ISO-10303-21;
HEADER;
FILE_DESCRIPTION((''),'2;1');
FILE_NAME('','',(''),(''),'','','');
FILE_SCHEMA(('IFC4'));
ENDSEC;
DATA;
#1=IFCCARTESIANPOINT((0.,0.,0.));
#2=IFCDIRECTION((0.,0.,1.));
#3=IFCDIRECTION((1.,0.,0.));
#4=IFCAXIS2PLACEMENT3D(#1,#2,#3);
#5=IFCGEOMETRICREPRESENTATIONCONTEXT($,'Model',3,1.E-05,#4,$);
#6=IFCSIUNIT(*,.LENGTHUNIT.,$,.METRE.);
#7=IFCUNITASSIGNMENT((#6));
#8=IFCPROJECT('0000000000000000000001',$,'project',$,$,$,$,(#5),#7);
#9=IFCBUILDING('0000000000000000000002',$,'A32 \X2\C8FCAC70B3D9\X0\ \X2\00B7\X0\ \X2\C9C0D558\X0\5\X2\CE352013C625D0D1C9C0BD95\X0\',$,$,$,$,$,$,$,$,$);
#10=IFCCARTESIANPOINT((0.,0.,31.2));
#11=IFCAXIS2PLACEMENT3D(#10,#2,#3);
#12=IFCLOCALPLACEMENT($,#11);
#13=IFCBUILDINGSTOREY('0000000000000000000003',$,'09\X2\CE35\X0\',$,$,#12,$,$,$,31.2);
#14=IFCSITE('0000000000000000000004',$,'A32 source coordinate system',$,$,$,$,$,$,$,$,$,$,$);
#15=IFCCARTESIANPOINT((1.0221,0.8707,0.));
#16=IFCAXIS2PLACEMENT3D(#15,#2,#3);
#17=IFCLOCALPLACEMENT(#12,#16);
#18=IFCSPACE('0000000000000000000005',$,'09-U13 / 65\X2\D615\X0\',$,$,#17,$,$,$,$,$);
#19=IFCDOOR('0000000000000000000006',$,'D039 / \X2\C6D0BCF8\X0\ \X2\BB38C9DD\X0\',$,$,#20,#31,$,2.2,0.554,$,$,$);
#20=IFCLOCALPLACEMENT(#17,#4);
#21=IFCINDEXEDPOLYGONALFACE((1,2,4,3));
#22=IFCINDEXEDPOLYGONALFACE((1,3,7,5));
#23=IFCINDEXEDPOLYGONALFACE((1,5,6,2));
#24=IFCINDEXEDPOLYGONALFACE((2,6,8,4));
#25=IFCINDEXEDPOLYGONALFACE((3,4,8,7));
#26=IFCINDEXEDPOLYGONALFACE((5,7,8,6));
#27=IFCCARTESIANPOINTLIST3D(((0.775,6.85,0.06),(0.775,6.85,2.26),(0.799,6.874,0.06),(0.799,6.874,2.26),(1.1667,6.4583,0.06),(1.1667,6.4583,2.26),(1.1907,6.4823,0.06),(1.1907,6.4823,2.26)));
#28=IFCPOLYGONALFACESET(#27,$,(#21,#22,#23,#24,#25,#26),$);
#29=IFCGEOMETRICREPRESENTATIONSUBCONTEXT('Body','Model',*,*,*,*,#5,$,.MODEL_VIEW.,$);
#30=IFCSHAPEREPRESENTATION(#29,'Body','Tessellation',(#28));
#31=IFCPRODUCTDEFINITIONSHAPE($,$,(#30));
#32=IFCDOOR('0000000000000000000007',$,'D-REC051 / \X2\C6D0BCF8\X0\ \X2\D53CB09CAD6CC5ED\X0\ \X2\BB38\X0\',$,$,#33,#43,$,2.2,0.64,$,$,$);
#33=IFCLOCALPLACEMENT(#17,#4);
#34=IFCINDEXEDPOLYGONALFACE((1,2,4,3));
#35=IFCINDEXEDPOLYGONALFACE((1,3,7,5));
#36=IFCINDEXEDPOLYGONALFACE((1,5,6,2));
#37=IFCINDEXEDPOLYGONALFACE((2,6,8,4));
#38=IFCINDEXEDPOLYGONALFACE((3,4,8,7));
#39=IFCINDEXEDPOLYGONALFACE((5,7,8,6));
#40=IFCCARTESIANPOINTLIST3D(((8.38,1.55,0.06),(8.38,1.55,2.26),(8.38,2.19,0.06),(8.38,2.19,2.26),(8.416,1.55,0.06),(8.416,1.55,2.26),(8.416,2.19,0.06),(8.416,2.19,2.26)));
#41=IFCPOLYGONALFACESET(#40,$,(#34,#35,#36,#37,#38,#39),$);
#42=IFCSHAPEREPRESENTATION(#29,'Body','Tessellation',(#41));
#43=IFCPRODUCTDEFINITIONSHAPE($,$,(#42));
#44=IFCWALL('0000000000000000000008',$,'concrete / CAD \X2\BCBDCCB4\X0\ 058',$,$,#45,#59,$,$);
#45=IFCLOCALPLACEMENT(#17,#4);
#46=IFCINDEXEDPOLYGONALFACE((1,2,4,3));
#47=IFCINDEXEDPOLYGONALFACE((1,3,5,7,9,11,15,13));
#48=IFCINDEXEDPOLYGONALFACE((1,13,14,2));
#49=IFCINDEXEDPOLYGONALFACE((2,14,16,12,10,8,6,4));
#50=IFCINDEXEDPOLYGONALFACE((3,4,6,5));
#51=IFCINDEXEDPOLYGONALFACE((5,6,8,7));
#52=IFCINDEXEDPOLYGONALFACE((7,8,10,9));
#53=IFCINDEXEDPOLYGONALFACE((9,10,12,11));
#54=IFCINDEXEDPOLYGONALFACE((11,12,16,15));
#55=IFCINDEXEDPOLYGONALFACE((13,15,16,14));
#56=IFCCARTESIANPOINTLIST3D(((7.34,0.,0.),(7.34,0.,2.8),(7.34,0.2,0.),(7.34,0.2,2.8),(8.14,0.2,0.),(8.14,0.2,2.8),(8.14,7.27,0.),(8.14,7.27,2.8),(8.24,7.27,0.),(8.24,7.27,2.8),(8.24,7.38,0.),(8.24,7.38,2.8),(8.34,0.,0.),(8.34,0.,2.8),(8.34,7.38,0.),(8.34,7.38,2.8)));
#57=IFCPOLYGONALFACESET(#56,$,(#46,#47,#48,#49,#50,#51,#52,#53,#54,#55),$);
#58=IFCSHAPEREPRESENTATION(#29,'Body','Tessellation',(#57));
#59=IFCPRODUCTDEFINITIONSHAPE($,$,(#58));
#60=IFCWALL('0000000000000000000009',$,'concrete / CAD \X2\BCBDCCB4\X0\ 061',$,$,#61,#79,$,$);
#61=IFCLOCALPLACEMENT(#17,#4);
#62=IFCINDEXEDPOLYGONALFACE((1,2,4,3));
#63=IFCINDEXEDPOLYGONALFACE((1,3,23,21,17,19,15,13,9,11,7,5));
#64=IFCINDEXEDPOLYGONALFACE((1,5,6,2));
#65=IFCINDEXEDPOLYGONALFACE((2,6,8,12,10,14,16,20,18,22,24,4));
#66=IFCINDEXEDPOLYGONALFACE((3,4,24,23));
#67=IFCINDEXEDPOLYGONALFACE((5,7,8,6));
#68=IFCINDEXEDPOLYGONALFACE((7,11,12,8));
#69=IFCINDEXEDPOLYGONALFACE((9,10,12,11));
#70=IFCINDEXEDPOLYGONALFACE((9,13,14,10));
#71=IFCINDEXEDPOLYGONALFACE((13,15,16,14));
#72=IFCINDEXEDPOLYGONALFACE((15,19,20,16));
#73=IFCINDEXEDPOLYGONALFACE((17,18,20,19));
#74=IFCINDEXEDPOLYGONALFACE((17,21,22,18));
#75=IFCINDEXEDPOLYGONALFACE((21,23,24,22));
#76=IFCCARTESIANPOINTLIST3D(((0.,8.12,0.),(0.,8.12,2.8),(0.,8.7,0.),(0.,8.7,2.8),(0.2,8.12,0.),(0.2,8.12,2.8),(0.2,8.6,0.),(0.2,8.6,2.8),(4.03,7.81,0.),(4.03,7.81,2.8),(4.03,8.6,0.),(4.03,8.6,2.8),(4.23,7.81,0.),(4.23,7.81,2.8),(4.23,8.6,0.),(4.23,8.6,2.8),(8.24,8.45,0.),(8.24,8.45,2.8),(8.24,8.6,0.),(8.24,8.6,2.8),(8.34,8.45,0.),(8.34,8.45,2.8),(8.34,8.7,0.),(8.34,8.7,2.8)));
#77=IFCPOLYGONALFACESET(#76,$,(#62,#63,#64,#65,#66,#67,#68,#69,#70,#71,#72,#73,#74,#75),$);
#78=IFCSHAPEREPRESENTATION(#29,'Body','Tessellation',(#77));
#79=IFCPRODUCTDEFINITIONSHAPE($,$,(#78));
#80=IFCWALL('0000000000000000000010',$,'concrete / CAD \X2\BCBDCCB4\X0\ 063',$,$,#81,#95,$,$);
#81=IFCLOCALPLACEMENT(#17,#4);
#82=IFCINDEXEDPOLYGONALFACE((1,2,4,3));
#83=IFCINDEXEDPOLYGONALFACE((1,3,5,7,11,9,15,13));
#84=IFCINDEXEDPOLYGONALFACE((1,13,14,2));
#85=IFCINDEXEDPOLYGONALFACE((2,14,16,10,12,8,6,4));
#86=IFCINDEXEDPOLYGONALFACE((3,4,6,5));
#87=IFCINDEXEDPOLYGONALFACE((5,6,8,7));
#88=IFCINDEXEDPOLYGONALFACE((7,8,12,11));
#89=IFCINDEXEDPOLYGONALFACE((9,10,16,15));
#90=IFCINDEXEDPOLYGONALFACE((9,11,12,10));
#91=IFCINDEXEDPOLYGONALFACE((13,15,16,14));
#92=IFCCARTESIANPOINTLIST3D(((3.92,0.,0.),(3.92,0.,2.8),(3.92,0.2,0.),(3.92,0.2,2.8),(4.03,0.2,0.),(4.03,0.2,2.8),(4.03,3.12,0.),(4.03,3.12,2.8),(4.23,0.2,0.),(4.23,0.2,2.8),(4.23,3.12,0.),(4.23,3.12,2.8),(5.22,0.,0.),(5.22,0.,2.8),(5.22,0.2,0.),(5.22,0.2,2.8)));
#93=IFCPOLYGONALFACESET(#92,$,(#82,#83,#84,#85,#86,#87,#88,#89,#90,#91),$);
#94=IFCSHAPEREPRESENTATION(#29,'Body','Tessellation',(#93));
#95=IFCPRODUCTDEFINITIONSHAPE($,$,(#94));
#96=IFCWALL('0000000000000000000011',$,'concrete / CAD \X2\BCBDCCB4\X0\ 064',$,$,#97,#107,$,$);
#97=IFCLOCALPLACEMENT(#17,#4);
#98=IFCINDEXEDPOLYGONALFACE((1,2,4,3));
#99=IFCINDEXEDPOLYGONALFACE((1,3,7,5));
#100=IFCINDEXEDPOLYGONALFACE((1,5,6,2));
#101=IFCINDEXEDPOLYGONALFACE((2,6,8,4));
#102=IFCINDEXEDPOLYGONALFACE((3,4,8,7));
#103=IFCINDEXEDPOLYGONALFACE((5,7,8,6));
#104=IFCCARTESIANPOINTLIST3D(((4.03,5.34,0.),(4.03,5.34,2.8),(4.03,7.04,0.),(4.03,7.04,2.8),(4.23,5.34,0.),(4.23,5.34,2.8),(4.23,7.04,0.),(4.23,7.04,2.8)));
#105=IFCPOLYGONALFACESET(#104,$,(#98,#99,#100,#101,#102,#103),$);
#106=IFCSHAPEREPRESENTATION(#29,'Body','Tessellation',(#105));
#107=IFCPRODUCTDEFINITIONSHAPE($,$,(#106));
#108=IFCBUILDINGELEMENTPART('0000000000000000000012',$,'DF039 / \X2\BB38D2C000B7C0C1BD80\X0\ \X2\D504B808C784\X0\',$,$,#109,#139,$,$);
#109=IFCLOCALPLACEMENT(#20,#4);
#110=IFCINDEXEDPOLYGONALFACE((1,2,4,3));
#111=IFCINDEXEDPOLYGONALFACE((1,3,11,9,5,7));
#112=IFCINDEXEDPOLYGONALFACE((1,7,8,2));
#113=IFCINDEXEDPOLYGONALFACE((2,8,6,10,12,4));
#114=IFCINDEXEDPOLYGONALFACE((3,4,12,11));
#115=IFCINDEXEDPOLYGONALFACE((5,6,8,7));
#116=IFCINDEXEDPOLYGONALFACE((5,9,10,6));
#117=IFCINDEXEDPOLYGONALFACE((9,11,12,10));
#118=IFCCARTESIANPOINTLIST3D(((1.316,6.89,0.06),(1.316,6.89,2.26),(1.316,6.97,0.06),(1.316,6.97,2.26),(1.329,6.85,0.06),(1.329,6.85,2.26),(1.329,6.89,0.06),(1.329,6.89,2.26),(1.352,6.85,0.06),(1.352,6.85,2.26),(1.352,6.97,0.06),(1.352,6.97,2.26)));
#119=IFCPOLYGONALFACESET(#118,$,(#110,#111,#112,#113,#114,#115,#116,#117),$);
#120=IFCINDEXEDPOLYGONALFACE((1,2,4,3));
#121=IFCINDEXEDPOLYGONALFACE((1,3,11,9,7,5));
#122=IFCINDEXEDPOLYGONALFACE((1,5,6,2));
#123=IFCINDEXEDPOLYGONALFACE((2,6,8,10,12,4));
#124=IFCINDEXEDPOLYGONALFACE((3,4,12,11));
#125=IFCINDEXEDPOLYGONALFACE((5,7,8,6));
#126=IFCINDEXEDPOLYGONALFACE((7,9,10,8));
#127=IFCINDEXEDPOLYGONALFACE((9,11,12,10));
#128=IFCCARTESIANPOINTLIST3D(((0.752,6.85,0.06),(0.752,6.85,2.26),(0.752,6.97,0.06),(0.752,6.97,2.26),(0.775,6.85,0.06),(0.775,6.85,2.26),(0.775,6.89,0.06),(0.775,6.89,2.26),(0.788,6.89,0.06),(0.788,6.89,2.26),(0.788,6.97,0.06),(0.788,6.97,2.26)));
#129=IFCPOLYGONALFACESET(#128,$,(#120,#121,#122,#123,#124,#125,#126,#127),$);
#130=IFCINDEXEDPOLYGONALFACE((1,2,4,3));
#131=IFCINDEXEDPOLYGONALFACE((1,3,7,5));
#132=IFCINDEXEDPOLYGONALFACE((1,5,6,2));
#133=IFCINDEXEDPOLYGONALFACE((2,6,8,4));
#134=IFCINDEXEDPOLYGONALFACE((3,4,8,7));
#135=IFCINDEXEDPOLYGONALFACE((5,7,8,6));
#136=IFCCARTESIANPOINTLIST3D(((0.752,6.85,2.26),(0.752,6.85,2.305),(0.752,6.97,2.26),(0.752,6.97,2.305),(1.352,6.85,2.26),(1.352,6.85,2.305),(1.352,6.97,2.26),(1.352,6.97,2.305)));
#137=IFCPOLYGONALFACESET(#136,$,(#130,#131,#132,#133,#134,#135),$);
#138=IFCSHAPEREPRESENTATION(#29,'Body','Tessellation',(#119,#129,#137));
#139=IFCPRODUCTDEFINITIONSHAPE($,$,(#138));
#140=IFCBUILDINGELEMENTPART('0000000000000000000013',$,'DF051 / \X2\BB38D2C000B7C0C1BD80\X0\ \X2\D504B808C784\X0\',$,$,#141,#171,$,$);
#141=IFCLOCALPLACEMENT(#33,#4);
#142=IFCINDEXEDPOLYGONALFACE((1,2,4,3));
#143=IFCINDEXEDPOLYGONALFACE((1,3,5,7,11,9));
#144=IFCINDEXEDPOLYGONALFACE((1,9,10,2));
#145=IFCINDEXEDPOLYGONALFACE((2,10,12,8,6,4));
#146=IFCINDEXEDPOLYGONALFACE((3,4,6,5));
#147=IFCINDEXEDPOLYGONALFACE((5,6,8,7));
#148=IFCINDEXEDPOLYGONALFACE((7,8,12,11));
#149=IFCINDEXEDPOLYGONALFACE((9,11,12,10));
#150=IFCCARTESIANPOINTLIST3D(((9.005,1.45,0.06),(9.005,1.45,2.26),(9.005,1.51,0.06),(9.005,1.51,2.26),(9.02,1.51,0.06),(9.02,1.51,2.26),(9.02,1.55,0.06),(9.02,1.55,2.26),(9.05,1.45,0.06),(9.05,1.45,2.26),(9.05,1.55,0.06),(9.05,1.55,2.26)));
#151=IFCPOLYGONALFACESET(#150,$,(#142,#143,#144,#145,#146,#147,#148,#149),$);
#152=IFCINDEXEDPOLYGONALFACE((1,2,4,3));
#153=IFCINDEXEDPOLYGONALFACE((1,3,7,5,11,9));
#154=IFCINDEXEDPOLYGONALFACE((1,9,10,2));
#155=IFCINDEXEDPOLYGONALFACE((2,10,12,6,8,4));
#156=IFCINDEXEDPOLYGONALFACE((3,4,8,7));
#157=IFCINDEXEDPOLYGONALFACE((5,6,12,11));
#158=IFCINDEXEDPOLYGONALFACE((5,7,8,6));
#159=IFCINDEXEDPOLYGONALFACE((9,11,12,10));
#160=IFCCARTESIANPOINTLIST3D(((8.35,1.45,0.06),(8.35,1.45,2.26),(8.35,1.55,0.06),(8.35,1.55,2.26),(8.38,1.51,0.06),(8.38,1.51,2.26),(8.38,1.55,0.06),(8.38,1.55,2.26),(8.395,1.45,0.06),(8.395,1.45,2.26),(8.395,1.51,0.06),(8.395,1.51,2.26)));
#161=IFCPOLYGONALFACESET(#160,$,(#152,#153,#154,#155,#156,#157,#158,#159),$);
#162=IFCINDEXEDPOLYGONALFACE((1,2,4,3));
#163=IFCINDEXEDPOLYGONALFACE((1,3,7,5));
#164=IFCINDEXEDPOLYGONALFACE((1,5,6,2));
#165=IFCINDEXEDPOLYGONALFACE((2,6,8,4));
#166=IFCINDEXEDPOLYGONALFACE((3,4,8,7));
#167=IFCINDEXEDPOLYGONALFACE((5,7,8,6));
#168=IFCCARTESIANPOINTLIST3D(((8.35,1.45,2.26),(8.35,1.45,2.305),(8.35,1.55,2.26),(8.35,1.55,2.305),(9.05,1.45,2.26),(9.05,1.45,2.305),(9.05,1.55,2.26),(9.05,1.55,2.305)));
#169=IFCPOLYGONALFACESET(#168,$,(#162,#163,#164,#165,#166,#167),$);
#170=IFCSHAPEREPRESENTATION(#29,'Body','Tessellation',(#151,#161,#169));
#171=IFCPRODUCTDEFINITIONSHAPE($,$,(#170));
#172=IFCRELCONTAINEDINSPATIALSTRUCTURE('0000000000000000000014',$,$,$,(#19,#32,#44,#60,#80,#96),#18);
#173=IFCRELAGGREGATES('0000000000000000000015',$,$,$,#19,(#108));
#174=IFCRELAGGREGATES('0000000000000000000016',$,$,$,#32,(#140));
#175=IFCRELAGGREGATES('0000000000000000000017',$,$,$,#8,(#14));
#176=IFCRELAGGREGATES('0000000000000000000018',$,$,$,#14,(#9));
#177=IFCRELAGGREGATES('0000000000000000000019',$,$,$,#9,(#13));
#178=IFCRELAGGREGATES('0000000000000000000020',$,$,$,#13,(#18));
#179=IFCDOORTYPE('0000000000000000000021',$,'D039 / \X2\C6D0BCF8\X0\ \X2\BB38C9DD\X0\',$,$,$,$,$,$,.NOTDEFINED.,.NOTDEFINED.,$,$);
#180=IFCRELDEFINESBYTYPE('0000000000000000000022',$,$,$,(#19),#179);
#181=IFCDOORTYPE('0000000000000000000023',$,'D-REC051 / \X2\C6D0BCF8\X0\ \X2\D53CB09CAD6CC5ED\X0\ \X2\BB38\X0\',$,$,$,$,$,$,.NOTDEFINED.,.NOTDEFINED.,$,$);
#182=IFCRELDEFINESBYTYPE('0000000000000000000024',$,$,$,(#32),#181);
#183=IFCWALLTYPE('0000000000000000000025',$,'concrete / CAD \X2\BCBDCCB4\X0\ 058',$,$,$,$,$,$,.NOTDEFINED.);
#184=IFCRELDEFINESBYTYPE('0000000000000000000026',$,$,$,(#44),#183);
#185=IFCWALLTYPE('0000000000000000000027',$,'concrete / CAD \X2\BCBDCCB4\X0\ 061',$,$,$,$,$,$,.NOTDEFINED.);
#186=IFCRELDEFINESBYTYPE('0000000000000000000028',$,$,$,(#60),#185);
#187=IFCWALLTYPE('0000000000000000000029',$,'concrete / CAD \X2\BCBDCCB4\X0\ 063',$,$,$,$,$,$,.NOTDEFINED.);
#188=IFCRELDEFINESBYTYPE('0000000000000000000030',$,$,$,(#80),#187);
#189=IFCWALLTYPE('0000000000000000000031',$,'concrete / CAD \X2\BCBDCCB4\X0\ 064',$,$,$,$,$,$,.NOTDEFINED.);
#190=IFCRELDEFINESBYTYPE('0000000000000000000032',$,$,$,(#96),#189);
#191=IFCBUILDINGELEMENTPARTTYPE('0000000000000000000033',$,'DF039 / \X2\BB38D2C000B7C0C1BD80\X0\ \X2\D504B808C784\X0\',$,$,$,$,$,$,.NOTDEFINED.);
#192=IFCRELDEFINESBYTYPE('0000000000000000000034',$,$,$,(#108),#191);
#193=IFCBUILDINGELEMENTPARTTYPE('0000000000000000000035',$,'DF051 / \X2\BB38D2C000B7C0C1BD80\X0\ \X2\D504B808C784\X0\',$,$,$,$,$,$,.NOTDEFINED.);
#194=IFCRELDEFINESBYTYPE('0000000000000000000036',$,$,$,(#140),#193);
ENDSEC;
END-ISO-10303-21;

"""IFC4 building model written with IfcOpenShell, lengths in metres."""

from ifc_helpers import new_model, si_unit, frame, origin, origin_with_axes, place, context, subcontext, project, spatial, polyline, outline, extrude, source, transform, mapped, type_object, type_shapes, element, aggregate, save


model = new_model("IFC4")

# Units and contexts
model_context = context("Model", 3, precision=1e-05, world=origin_with_axes())
body_context = subcontext(model_context, "Body", "Model", "MODEL_VIEW")
ifc_project = project(units=[si_unit("LENGTHUNIT", "METRE")], contexts=[model_context])

# Site, building, storey, space
storey_placement = place(None, frame((0.0, 0.0, 31.2), z_axis=(0.0, 0.0, 1.0), x_axis=(1.0, 0.0, 0.0)))
space_placement = place(storey_placement, frame((1.0221, 0.8707, 0.0), z_axis=(0.0, 0.0, 1.0), x_axis=(1.0, 0.0, 0.0)))
site = spatial("IfcSite", under=ifc_project, Name="A32 source coordinate system")
building = spatial("IfcBuilding", under=site, Name="A32 주거동 · 지하5층–옥탑지붕")
storey = spatial("IfcBuildingStorey", under=building, at=storey_placement, Name="09층", Elevation=31.2)
space = spatial("IfcSpace", under=storey, at=space_placement, Name="09-U13 / 65형")

# Doors
door_type_1 = type_object("IfcDoorType", Name="D039 / 원본 문짝", OperationType="NOTDEFINED", PredefinedType="NOTDEFINED")
shared_shape_1 = source(origin(), body_context, "Body", "SweptSolid", [
    extrude(outline(polyline([(1.1907, 6.4823), (1.1667, 6.4583), (0.775, 6.85), (0.799, 6.874), (1.1907, 6.4823)])), frame((0.0, 0.0, 0.06)), (0.0, 0.0, 1.0), 2.2),
])
type_shapes(door_type_1, [shared_shape_1])
door_1_placement = place(space_placement, origin_with_axes())
door_1 = element("IfcDoor", 1, at=door_1_placement, inside=space, type_object=door_type_1, Name="D039 / 원본 문짝", OverallHeight=2.2, OverallWidth=0.554, context=body_context, shape_type="MappedRepresentation", body=[
    mapped(shared_shape_1, transform((0.0, 0.0, 0.0), scale=1.0)),
])
door_type_2 = type_object("IfcDoorType", Name="D-REC051 / 원본 피난구역 문", OperationType="NOTDEFINED", PredefinedType="NOTDEFINED")
shared_shape_2 = source(origin(), body_context, "Body", "SweptSolid", [
    extrude(outline(polyline([(8.416, 2.19), (8.416, 1.55), (8.38, 1.55), (8.38, 2.19), (8.416, 2.19)])), frame((0.0, 0.0, 0.06)), (0.0, 0.0, 1.0), 2.2),
])
type_shapes(door_type_2, [shared_shape_2])
door_2_placement = place(space_placement, origin_with_axes())
door_2 = element("IfcDoor", 2, at=door_2_placement, inside=space, type_object=door_type_2, Name="D-REC051 / 원본 피난구역 문", OverallHeight=2.2, OverallWidth=0.64, context=body_context, shape_type="MappedRepresentation", body=[
    mapped(shared_shape_2, transform((0.0, 0.0, 0.0), scale=1.0)),
])

# Walls
wall_type_1 = type_object("IfcWallType", Name="concrete / CAD 벽체 058", PredefinedType="NOTDEFINED")
shared_shape_3 = source(origin(), body_context, "Body", "SweptSolid", [
    extrude(outline(polyline([(8.34, 0.0), (7.34, 0.0), (7.34, 0.2), (8.14, 0.2), (8.14, 7.27), (8.24, 7.27), (8.24, 7.38), (8.34, 7.38), (8.34, 0.0)])), origin(), (0.0, 0.0, 1.0), 2.8),
])
type_shapes(wall_type_1, [shared_shape_3])
wall_1_placement = place(space_placement, origin_with_axes())
element("IfcWall", 3, at=wall_1_placement, inside=space, type_object=wall_type_1, Name="concrete / CAD 벽체 058", context=body_context, shape_type="MappedRepresentation", body=[
    mapped(shared_shape_3, transform((0.0, 0.0, 0.0), scale=1.0)),
])
wall_type_2 = type_object("IfcWallType", Name="concrete / CAD 벽체 061", PredefinedType="NOTDEFINED")
shared_shape_4 = source(origin(), body_context, "Body", "SweptSolid", [
    extrude(outline(polyline([(0.2, 8.6), (0.2, 8.12), (0.0, 8.12), (0.0, 8.7), (8.34, 8.7), (8.34, 8.45), (8.24, 8.45), (8.24, 8.6), (4.23, 8.6), (4.23, 7.81), (4.03, 7.81), (4.03, 8.6), (0.2, 8.6)])), origin(), (0.0, 0.0, 1.0), 2.8),
])
type_shapes(wall_type_2, [shared_shape_4])
wall_2_placement = place(space_placement, origin_with_axes())
element("IfcWall", 4, at=wall_2_placement, inside=space, type_object=wall_type_2, Name="concrete / CAD 벽체 061", context=body_context, shape_type="MappedRepresentation", body=[
    mapped(shared_shape_4, transform((0.0, 0.0, 0.0), scale=1.0)),
])
wall_type_3 = type_object("IfcWallType", Name="concrete / CAD 벽체 063", PredefinedType="NOTDEFINED")
shared_shape_5 = source(origin(), body_context, "Body", "SweptSolid", [
    extrude(outline(polyline([(5.22, 0.0), (3.92, 0.0), (3.92, 0.2), (4.03, 0.2), (4.03, 3.12), (4.23, 3.12), (4.23, 0.2), (5.22, 0.2), (5.22, 0.0)])), origin(), (0.0, 0.0, 1.0), 2.8),
])
type_shapes(wall_type_3, [shared_shape_5])
wall_3_placement = place(space_placement, origin_with_axes())
element("IfcWall", 5, at=wall_3_placement, inside=space, type_object=wall_type_3, Name="concrete / CAD 벽체 063", context=body_context, shape_type="MappedRepresentation", body=[
    mapped(shared_shape_5, transform((0.0, 0.0, 0.0), scale=1.0)),
])
wall_type_4 = type_object("IfcWallType", Name="concrete / CAD 벽체 064", PredefinedType="NOTDEFINED")
shared_shape_6 = source(origin(), body_context, "Body", "SweptSolid", [
    extrude(outline(polyline([(4.03, 7.04), (4.23, 7.04), (4.23, 5.34), (4.03, 5.34), (4.03, 7.04)])), origin(), (0.0, 0.0, 1.0), 2.8),
])
type_shapes(wall_type_4, [shared_shape_6])
wall_4_placement = place(space_placement, origin_with_axes())
element("IfcWall", 6, at=wall_4_placement, inside=space, type_object=wall_type_4, Name="concrete / CAD 벽체 064", context=body_context, shape_type="MappedRepresentation", body=[
    mapped(shared_shape_6, transform((0.0, 0.0, 0.0), scale=1.0)),
])

# Building element parts
building_element_part_type_1 = type_object("IfcBuildingElementPartType", Name="DF039 / 문틀·상부 프레임", PredefinedType="NOTDEFINED")
shared_shape_7 = source(origin(), body_context, "Body", "SweptSolid", [
    extrude(outline(polyline([(1.352, 6.85), (1.329, 6.85), (1.329, 6.89), (1.316, 6.89), (1.316, 6.97), (1.352, 6.97), (1.352, 6.85)])), frame((0.0, 0.0, 0.06)), (0.0, 0.0, 1.0), 2.2),
    extrude(outline(polyline([(0.788, 6.97), (0.788, 6.89), (0.775, 6.89), (0.775, 6.85), (0.752, 6.85), (0.752, 6.97), (0.788, 6.97)])), frame((0.0, 0.0, 0.06)), (0.0, 0.0, 1.0), 2.2),
    extrude(outline(polyline([(0.752, 6.85), (0.752, 6.97), (1.352, 6.97), (1.352, 6.85), (0.752, 6.85)])), frame((0.0, 0.0, 2.26)), (0.0, 0.0, 1.0), 0.045),
])
type_shapes(building_element_part_type_1, [shared_shape_7])
building_element_part_1_placement = place(door_1_placement, origin_with_axes())
building_element_part_1 = element("IfcBuildingElementPart", 7, at=building_element_part_1_placement, type_object=building_element_part_type_1, Name="DF039 / 문틀·상부 프레임", context=body_context, shape_type="MappedRepresentation", body=[
    mapped(shared_shape_7, transform((0.0, 0.0, 0.0), scale=1.0)),
])
aggregate(door_1, [building_element_part_1])
building_element_part_type_2 = type_object("IfcBuildingElementPartType", Name="DF051 / 문틀·상부 프레임", PredefinedType="NOTDEFINED")
shared_shape_8 = source(origin(), body_context, "Body", "SweptSolid", [
    extrude(outline(polyline([(9.05, 1.45), (9.005, 1.45), (9.005, 1.51), (9.02, 1.51), (9.02, 1.55), (9.05, 1.55), (9.05, 1.45)])), frame((0.0, 0.0, 0.06)), (0.0, 0.0, 1.0), 2.2),
    extrude(outline(polyline([(8.38, 1.55), (8.38, 1.51), (8.395, 1.51), (8.395, 1.45), (8.35, 1.45), (8.35, 1.55), (8.38, 1.55)])), frame((0.0, 0.0, 0.06)), (0.0, 0.0, 1.0), 2.2),
    extrude(outline(polyline([(8.35, 1.45), (8.35, 1.55), (9.05, 1.55), (9.05, 1.45), (8.35, 1.45)])), frame((0.0, 0.0, 2.26)), (0.0, 0.0, 1.0), 0.045),
])
type_shapes(building_element_part_type_2, [shared_shape_8])
building_element_part_2_placement = place(door_2_placement, origin_with_axes())
building_element_part_2 = element("IfcBuildingElementPart", 8, at=building_element_part_2_placement, type_object=building_element_part_type_2, Name="DF051 / 문틀·상부 프레임", context=body_context, shape_type="MappedRepresentation", body=[
    mapped(shared_shape_8, transform((0.0, 0.0, 0.0), scale=1.0)),
])
aggregate(door_2, [building_element_part_2])

save(model, "model.ifc")
